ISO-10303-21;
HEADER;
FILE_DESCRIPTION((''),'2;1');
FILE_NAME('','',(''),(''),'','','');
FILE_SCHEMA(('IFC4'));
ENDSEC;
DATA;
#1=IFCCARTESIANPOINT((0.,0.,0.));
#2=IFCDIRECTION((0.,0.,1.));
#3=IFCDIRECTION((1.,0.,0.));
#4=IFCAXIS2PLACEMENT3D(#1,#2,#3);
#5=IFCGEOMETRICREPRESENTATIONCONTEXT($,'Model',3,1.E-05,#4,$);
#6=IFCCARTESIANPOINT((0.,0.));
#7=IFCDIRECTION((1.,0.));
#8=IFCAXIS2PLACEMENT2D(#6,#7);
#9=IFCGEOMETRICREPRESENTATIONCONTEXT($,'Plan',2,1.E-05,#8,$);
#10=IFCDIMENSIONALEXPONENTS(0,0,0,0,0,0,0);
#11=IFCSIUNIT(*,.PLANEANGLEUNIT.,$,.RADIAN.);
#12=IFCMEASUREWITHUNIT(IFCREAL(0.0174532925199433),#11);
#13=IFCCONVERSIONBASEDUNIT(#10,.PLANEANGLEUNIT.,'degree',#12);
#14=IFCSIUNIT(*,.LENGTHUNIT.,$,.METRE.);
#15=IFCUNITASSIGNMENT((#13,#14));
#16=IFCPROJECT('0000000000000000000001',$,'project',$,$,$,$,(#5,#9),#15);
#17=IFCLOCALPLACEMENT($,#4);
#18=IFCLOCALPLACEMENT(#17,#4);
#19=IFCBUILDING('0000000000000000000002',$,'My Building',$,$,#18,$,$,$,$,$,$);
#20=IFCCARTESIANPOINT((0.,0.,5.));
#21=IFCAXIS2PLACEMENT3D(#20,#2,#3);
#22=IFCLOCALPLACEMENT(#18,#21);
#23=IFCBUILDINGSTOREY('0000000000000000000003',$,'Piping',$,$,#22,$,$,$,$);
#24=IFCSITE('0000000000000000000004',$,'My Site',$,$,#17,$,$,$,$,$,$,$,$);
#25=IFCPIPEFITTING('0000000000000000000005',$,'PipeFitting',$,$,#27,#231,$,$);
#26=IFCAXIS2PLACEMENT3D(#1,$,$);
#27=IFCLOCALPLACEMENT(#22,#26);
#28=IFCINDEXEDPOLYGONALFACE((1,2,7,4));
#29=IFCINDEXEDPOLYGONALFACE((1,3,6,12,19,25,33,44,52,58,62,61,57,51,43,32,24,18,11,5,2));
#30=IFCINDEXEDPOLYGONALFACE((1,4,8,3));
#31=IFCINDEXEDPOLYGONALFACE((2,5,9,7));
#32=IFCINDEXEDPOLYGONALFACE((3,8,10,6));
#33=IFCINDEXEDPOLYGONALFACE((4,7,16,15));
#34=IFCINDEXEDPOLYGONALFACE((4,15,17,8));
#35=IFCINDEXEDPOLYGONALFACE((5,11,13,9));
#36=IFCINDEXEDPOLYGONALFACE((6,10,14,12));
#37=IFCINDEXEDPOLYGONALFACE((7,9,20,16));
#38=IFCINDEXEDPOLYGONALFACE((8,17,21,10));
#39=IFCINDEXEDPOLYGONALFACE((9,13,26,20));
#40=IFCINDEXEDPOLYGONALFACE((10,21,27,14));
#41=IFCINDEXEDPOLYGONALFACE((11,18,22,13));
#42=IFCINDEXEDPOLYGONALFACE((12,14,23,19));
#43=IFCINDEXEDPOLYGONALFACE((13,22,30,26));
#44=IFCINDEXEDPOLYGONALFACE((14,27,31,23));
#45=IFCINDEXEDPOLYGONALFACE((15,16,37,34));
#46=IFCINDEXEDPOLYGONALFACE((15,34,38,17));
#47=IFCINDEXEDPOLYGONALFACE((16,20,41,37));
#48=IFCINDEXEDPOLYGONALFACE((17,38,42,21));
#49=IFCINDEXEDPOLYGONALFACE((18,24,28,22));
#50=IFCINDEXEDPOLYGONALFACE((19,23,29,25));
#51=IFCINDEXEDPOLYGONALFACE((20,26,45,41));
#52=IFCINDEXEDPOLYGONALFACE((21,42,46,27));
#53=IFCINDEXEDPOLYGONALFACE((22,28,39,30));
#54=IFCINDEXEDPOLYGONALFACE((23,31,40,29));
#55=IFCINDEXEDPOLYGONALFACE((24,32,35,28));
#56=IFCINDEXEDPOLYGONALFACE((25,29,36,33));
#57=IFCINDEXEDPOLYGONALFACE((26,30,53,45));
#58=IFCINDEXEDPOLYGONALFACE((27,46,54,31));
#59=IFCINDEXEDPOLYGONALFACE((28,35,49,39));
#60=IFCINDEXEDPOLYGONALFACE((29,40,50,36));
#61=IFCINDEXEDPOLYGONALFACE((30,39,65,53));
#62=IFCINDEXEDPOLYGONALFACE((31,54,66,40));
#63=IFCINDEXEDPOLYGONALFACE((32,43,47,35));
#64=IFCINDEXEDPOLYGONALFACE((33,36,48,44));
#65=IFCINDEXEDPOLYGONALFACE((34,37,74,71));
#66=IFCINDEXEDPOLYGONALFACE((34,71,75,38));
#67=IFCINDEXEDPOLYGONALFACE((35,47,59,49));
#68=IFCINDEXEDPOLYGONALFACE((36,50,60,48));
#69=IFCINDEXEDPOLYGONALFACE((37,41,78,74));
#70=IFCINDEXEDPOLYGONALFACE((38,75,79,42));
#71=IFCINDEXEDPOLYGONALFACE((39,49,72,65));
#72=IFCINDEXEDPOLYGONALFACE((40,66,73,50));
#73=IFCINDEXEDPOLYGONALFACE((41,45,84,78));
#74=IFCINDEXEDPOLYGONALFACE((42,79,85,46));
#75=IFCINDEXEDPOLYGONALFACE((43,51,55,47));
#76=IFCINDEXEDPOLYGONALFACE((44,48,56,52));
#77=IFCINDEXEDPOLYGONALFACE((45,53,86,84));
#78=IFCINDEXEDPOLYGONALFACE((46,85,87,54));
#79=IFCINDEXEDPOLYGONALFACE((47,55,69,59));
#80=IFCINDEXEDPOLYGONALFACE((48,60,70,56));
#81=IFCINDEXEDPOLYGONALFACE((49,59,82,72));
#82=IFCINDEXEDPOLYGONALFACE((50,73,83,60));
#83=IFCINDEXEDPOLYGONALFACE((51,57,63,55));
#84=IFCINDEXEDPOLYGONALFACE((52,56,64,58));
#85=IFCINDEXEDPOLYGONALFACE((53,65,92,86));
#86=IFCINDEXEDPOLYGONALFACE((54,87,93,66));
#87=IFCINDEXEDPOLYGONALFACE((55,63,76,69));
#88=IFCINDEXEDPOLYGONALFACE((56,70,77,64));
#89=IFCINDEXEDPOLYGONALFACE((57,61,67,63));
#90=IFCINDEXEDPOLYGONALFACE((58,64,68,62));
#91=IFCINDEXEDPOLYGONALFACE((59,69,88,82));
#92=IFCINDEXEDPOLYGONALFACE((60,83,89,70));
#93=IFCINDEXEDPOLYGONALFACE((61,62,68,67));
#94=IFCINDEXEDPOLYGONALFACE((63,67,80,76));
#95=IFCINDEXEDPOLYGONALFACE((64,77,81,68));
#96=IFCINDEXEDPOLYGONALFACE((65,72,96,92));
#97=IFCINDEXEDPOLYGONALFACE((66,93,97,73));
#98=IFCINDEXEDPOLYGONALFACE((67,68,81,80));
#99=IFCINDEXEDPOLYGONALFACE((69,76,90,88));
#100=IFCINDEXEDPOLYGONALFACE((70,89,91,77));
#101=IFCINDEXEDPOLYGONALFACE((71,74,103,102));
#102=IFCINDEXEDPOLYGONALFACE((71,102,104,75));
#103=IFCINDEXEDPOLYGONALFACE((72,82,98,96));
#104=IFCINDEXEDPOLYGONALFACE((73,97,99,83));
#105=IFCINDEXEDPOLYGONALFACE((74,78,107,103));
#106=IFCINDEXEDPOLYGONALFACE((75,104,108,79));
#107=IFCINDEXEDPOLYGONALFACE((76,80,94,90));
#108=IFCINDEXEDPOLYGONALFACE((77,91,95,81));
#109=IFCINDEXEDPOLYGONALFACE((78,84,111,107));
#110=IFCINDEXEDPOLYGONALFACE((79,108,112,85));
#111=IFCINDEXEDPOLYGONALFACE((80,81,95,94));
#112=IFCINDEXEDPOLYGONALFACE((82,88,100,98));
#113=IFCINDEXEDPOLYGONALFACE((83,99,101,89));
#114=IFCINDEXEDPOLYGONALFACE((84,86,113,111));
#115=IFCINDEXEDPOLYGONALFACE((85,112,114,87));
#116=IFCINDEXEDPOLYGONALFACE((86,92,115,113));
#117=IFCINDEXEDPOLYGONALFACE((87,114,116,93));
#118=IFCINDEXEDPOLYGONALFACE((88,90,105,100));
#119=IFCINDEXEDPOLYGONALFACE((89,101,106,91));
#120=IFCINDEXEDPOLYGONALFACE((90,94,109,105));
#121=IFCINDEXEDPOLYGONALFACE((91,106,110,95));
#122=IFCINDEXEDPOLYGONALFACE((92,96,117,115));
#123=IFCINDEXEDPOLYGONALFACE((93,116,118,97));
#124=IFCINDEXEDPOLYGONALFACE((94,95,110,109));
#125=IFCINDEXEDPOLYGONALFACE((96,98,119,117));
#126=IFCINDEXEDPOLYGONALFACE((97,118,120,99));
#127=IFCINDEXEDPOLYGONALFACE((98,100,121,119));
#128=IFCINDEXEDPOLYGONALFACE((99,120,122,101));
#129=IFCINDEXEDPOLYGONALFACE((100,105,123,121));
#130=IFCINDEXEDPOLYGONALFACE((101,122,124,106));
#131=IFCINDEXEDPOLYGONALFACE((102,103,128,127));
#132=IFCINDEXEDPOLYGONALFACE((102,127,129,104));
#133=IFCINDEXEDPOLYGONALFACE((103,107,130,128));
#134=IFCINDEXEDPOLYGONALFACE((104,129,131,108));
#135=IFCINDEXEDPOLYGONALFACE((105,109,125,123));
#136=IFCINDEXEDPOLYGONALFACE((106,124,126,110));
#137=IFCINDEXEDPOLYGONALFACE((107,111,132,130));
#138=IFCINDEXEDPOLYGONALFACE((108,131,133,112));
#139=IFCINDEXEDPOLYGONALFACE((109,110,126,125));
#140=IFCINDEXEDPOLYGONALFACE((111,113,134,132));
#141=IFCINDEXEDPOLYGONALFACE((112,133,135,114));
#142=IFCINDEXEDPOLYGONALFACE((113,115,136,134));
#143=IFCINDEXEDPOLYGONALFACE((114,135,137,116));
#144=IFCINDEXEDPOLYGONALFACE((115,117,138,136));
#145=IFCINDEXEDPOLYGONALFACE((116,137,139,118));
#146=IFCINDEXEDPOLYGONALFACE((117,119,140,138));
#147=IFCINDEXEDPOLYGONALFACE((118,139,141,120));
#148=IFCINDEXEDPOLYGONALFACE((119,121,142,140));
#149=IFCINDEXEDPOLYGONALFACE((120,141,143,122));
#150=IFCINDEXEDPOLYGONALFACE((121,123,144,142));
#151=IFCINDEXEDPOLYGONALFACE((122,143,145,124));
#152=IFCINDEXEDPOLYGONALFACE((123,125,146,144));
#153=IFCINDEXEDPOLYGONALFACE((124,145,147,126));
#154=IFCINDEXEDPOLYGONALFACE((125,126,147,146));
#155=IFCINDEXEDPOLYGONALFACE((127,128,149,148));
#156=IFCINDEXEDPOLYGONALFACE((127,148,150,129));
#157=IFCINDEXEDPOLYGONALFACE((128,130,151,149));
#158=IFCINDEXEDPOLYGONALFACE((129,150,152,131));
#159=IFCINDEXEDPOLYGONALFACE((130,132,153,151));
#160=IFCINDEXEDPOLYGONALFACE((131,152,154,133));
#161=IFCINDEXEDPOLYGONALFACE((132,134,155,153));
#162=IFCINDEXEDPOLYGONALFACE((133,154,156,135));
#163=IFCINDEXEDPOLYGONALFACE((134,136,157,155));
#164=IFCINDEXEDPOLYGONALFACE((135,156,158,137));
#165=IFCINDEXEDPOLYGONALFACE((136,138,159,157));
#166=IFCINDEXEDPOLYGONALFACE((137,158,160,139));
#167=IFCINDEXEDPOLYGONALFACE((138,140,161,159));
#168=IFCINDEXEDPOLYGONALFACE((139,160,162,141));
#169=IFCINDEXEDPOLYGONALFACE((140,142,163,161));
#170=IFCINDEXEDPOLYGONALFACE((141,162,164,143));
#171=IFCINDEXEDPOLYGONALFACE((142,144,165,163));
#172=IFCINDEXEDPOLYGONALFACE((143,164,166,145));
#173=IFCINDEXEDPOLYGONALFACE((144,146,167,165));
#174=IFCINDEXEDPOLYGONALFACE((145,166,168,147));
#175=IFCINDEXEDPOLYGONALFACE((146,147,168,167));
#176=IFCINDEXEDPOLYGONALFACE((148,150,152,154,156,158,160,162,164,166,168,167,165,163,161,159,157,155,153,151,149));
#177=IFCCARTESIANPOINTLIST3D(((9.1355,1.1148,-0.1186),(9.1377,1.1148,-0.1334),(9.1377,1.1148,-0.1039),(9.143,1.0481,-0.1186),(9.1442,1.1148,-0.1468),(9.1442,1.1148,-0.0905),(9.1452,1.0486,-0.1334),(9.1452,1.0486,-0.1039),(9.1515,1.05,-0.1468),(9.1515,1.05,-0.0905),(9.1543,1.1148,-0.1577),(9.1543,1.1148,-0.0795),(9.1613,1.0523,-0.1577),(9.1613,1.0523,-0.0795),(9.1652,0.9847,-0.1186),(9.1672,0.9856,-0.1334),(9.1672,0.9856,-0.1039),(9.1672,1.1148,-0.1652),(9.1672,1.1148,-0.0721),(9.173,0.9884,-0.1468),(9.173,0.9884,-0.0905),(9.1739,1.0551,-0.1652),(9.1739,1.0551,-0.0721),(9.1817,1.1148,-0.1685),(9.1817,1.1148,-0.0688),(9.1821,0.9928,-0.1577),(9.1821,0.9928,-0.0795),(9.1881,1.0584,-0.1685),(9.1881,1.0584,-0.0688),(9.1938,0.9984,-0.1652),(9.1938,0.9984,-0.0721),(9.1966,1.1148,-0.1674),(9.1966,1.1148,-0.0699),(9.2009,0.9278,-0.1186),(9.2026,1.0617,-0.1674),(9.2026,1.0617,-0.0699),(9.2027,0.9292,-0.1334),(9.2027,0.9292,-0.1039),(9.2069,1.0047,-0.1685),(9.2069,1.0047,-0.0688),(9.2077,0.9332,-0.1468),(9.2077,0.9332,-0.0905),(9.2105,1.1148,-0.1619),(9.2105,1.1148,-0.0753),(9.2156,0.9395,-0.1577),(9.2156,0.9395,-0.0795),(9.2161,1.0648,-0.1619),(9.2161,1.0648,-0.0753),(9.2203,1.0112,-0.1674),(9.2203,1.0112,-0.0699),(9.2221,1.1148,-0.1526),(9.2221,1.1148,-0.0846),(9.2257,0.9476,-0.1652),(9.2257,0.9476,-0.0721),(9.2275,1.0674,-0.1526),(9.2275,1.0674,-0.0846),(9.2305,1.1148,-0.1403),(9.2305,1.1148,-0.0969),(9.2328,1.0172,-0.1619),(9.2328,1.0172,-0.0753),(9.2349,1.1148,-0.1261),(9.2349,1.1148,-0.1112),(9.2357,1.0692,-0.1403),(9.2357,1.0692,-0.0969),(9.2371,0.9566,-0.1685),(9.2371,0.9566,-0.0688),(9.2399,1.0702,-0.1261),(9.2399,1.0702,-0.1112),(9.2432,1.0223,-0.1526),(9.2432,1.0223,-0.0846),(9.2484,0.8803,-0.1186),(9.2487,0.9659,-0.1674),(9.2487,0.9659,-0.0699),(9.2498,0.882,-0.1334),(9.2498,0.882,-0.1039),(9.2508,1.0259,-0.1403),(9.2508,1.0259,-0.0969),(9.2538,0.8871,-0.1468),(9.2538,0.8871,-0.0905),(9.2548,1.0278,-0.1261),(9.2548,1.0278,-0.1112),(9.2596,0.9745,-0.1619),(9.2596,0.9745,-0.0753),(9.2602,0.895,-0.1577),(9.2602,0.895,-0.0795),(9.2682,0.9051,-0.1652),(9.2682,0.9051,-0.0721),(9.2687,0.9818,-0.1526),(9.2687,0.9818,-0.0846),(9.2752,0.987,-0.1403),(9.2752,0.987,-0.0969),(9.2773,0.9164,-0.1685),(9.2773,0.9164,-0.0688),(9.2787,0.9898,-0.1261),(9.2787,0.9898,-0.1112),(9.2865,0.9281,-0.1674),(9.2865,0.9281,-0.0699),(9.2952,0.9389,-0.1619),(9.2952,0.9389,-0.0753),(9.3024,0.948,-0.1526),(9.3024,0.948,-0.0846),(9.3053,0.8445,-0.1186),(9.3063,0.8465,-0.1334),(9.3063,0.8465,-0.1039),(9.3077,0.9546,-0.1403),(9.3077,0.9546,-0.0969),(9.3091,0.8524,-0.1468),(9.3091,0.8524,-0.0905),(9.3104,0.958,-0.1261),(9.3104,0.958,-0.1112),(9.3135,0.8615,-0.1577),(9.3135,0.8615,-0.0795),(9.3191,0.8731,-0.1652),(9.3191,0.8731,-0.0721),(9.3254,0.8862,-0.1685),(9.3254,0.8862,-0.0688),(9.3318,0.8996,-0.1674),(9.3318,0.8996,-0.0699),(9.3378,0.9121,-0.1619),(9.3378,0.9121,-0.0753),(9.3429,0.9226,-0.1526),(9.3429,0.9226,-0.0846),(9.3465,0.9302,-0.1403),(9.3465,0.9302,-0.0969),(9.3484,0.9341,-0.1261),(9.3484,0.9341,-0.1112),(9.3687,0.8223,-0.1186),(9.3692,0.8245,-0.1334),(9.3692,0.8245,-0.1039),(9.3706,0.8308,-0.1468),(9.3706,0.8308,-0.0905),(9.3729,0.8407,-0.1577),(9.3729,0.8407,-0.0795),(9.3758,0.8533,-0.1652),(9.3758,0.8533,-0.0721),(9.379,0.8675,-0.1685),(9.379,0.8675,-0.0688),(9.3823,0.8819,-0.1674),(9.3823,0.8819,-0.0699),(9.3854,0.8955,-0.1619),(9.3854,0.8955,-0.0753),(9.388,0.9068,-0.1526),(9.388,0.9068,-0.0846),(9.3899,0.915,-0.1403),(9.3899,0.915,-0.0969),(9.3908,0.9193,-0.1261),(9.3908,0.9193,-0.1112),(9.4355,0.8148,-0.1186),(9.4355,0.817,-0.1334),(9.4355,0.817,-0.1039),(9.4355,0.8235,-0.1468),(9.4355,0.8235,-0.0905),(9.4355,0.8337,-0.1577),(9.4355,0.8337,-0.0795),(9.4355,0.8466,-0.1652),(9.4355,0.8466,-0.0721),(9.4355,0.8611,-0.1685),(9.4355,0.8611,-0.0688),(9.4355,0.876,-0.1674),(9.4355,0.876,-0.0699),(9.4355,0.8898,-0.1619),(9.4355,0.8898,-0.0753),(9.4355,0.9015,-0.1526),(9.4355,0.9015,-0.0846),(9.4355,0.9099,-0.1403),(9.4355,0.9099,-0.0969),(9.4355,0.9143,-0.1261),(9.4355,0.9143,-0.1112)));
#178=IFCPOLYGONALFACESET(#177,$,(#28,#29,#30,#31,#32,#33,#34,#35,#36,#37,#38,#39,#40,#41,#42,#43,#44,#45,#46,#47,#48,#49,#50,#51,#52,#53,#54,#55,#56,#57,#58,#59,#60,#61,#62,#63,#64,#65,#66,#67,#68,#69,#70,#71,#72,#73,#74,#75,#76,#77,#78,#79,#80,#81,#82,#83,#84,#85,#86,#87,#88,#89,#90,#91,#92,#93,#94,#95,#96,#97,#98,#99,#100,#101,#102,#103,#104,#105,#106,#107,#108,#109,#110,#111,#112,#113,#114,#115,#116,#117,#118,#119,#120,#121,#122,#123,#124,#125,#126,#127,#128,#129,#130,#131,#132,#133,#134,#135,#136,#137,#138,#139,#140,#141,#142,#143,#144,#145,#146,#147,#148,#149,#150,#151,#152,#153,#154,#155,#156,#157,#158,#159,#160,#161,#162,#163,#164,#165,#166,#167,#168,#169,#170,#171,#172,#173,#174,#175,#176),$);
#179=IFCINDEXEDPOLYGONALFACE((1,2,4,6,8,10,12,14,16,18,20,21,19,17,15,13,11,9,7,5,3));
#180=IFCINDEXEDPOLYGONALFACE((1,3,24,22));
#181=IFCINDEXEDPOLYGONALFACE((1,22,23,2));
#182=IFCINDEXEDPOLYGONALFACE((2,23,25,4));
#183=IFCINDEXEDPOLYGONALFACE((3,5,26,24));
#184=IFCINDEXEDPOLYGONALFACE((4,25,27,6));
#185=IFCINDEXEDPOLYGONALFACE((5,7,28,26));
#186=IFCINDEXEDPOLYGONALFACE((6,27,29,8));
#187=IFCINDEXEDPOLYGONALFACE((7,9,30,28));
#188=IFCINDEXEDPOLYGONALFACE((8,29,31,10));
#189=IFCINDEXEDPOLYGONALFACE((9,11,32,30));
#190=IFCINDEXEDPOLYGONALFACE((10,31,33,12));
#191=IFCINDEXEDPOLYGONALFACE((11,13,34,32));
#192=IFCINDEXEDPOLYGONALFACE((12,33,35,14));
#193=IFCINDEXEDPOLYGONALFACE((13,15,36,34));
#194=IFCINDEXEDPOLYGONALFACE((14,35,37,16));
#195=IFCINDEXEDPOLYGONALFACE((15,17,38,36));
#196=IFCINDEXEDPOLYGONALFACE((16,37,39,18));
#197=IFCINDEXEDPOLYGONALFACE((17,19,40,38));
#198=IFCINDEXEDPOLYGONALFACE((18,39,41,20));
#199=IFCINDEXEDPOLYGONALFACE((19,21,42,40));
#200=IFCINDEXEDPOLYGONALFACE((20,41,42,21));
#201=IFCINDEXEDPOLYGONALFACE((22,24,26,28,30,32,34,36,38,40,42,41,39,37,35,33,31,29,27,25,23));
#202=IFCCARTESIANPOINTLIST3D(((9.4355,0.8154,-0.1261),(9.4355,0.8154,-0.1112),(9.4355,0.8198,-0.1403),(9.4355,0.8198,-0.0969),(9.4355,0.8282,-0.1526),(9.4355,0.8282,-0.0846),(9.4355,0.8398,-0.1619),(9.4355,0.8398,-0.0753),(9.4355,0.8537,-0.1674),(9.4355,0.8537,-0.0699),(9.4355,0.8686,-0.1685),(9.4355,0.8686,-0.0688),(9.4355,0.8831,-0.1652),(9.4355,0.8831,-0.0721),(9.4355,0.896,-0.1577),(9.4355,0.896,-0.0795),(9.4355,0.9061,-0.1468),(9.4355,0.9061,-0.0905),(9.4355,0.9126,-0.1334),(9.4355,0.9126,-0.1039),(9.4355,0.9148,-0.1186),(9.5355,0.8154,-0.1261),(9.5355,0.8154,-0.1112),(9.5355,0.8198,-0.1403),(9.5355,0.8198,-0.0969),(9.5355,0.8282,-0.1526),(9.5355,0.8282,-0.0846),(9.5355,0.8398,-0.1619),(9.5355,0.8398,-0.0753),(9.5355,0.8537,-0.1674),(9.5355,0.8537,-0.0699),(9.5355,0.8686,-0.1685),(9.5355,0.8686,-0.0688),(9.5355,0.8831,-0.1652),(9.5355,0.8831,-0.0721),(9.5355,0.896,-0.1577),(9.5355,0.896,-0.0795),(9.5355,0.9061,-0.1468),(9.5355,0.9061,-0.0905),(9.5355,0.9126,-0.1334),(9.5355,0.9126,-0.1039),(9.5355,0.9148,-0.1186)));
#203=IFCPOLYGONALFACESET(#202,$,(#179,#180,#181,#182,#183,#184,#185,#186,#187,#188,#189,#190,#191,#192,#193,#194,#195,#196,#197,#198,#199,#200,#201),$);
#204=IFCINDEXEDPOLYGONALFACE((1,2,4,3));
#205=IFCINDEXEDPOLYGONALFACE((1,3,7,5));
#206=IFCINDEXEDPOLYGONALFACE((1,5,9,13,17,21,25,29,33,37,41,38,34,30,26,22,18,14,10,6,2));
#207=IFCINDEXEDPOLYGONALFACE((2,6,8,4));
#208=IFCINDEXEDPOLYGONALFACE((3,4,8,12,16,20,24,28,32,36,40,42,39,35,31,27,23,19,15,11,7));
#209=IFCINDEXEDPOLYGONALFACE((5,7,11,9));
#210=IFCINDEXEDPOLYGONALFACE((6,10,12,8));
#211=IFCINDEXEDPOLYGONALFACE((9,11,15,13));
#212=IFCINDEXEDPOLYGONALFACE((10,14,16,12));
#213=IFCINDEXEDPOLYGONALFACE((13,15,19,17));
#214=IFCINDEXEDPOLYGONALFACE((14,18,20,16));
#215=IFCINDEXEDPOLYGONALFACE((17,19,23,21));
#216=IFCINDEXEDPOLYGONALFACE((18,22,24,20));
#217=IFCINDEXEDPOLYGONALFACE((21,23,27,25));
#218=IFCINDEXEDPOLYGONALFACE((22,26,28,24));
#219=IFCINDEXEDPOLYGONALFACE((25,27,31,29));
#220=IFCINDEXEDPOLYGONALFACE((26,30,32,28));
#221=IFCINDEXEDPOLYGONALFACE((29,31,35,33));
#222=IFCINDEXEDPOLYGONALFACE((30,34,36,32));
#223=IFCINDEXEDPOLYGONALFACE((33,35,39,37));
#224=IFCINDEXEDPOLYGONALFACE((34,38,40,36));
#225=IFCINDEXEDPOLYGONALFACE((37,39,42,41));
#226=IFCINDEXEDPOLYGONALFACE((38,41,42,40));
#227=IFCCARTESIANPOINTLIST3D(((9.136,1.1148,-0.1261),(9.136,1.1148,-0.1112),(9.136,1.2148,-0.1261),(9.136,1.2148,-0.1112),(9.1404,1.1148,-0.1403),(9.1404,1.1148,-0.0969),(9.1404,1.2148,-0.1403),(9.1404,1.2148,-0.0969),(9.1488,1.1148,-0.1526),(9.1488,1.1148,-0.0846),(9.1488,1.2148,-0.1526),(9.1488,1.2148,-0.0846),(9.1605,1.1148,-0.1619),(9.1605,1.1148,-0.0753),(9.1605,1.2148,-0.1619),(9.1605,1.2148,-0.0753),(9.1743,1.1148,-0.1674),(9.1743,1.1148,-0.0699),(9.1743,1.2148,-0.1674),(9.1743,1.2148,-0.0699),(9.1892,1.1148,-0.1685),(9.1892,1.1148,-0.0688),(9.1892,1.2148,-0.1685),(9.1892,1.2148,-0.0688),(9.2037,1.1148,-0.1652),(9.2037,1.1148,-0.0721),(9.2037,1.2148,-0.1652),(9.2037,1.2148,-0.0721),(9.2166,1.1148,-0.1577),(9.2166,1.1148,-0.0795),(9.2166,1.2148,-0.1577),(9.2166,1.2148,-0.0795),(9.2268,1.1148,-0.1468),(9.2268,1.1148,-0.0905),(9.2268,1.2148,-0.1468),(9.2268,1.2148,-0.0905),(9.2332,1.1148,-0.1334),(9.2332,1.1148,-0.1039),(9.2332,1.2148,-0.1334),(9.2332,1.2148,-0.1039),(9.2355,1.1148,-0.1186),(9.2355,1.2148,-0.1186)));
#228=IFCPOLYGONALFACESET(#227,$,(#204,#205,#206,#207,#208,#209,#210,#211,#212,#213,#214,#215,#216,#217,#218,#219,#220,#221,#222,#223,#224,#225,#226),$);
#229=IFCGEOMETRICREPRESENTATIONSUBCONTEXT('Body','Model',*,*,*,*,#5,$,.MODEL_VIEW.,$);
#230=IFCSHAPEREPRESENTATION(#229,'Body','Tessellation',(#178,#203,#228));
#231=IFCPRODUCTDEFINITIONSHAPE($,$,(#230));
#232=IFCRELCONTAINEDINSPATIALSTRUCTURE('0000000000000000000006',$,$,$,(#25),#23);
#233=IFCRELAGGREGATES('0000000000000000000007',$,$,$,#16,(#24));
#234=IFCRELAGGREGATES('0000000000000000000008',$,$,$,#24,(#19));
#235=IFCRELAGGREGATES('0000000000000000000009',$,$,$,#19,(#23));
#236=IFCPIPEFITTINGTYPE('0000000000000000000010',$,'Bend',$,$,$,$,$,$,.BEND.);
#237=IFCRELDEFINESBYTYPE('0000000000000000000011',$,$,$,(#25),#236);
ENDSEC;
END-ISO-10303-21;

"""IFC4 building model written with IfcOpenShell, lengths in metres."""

from ifc_helpers import new_model, entity, si_unit, converted_unit, frame, origin_with_axes, origin_2d_with_axis, place, context, subcontext, project, spatial, circle, extrude, source, transform, mapped, type_object, type_shapes, element, save


model = new_model("IFC4")

# Units and contexts
model_context = context("Model", 3, precision=1e-05, world=origin_with_axes())
plan_context = context("Plan", 2, precision=1e-05, world=origin_2d_with_axis())
body_context = subcontext(model_context, "Body", "Model", "MODEL_VIEW")
ifc_project = project(units=[converted_unit("PLANEANGLEUNIT", "degree", entity("IfcReal", 0.0174532925199433), si_unit("PLANEANGLEUNIT", "RADIAN"), dimensions=[0, 0, 0, 0, 0, 0, 0]), si_unit("LENGTHUNIT", "METRE")], contexts=[model_context, plan_context])

# Site, building, storey
site_placement = place(None, origin_with_axes())
site = spatial("IfcSite", under=ifc_project, at=site_placement, Name="My Site")
building_placement = place(site_placement, origin_with_axes())
building = spatial("IfcBuilding", under=site, at=building_placement, Name="My Building")
storey_placement = place(building_placement, frame((0.0, 0.0, 5.0), z_axis=(0.0, 0.0, 1.0), x_axis=(1.0, 0.0, 0.0)))
storey = spatial("IfcBuildingStorey", under=building, at=storey_placement, Name="Piping")

# Pipe fitting
pipe_fitting_type_1 = type_object("IfcPipeFittingType", Name="Bend", PredefinedType="BEND")
shared_shape = source(origin_with_axes(), body_context, "Body", "SolidModel", [
    entity("IfcSweptDiskSolid", entity("IfcIndexedPolyCurve", entity("IfcCartesianPointList3D", [[0.0, 0.0, -0.1], [0.0732, 0.0, -0.2768], [0.25, 0.0, -0.35]]), [entity("IfcArcIndex", [1, 2, 3])]), 0.05),
    extrude(circle(Radius=0.05), origin_with_axes(), (0.0, 0.0, -1.0), 0.1),
    extrude(circle(Radius=0.05), frame((0.25, 0.0, -0.35), z_axis=(1.0, 0.0, 0.0), x_axis=(0.0, 0.0, 1.0)), (0.0, 0.0, 1.0), 0.1),
])
type_shapes(pipe_fitting_type_1, [shared_shape])
for number, where, z_axis, x_axis, name in (
    (1, (9.5355, 0.8648, -0.1186), (1.0, 0.0, 0.0), (0.0, 1.0, 0.0), "PipeFitting"),
):
    element("IfcPipeFitting", number, at=place(storey_placement, frame(where, z_axis=z_axis, x_axis=x_axis)), inside=storey, type_object=pipe_fitting_type_1, Name=name, context=body_context, shape_type="MappedRepresentation", body=[
        mapped(shared_shape, transform((0.0, 0.0, 0.0), x_axis=(1.0, 0.0, 0.0), y_axis=(0.0, 1.0, 0.0), z_axis=(0.0, 0.0, 1.0), scale=1.0)),
    ])

save(model, "model.ifc")
